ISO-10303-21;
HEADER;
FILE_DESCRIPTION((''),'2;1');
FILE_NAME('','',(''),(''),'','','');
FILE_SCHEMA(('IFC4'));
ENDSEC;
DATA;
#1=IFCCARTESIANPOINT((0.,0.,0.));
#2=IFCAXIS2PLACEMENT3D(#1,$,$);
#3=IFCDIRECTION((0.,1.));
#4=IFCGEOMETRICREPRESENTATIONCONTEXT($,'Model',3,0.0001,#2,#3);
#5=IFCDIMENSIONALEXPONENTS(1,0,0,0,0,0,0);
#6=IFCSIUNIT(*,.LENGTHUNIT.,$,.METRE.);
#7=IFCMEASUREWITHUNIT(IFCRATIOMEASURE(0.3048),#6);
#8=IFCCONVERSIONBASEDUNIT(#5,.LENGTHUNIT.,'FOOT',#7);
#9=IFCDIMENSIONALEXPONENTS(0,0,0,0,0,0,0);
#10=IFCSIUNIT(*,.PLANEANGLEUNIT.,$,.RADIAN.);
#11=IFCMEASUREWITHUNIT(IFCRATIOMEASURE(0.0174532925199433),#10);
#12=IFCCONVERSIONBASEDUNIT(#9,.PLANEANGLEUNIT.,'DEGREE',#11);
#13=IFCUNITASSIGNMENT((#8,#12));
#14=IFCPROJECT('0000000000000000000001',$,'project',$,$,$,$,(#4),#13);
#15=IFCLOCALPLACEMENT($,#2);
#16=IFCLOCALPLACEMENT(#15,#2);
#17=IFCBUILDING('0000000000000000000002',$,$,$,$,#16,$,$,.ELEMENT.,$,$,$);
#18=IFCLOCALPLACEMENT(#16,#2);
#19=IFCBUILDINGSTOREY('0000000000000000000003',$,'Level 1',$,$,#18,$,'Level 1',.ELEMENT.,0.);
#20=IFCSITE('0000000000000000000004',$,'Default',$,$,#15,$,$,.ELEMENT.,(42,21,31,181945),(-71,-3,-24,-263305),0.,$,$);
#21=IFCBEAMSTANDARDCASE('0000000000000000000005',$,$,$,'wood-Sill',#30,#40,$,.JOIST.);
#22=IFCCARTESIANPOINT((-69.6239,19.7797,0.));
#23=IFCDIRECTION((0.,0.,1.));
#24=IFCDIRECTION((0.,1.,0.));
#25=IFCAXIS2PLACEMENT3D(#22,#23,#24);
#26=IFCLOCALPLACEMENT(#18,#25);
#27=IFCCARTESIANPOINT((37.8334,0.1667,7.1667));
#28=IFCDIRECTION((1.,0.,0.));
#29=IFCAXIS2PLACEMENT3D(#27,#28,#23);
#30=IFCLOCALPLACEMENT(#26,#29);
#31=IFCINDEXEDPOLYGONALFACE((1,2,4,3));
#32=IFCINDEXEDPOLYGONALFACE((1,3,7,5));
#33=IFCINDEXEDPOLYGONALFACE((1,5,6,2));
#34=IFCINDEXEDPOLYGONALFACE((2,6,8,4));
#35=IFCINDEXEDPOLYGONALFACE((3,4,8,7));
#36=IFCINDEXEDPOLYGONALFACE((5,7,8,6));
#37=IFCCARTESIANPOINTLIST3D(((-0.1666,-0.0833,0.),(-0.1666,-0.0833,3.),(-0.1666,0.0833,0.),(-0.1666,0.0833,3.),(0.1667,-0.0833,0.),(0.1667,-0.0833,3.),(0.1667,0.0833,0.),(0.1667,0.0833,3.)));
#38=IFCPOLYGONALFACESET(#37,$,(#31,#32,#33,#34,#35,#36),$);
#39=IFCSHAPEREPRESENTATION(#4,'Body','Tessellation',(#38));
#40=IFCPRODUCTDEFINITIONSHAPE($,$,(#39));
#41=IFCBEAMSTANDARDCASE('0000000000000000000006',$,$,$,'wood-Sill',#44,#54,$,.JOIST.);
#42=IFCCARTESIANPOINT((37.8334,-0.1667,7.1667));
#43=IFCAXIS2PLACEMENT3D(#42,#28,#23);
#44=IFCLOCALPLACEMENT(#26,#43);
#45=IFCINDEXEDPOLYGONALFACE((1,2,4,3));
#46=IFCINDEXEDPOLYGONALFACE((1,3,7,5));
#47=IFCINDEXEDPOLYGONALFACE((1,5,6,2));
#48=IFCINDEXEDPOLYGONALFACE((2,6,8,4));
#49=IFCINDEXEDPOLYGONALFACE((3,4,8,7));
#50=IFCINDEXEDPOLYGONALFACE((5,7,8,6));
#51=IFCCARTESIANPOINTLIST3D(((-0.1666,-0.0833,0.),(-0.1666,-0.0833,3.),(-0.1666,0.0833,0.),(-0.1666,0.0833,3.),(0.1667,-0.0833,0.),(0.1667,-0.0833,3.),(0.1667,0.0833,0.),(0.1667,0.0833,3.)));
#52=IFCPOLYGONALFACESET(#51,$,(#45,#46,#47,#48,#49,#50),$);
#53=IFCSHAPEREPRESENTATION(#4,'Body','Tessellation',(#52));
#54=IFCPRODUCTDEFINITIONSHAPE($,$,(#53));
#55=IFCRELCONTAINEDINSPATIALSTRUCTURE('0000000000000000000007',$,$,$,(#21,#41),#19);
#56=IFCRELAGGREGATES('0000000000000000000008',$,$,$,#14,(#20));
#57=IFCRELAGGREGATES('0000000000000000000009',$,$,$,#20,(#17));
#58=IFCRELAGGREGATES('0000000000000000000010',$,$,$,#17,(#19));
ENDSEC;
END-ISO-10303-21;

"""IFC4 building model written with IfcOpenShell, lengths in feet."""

from ifc_helpers import new_model, entity, si_unit, converted_unit, direction, frame, origin, origin_with_axes, place, context, project, spatial, rectangle, extrude, element, save


model = new_model("IFC4")

# Units and contexts
model_context = context("Model", 3, precision=0.0001, world=origin(), true_north=direction((0.0, 1.0)))
ifc_project = project(units=[converted_unit("LENGTHUNIT", "FOOT", entity("IfcRatioMeasure", 0.3048), si_unit("LENGTHUNIT", "METRE"), dimensions=[1, 0, 0, 0, 0, 0, 0]), converted_unit("PLANEANGLEUNIT", "DEGREE", entity("IfcRatioMeasure", 0.0174532925199433), si_unit("PLANEANGLEUNIT", "RADIAN"), dimensions=[0, 0, 0, 0, 0, 0, 0])], contexts=[model_context])

# Site, building, storey
site_placement = place(None, origin())
site = spatial("IfcSite", under=ifc_project, at=site_placement, Name="Default", CompositionType="ELEMENT", RefLatitude=(42, 21, 31, 181945), RefLongitude=(-71, -3, -24, -263305), RefElevation=0.0)
building_placement = place(site_placement, origin())
building = spatial("IfcBuilding", under=site, at=building_placement, CompositionType="ELEMENT")
storey_placement = place(building_placement, origin())
storey = spatial("IfcBuildingStorey", under=building, at=storey_placement, Name="Level 1", LongName="Level 1", CompositionType="ELEMENT", Elevation=0.0)

# Shared definitions
placement_1 = place(storey_placement, frame((-69.6239, 19.7797, 0.0), z_axis=(0.0, 0.0, 1.0), x_axis=(0.0, 1.0, 0.0)))

# Beams
for number, where, z_axis, x_axis in (
    (1, (37.8334, 0.1667, 7.1667), (1.0, 0.0, 0.0), (0.0, 0.0, 1.0)),
    (2, (37.8334, -0.1667, 7.1667), (1.0, 0.0, 0.0), (0.0, 0.0, 1.0)),
):
    element("IfcBeamStandardCase", number, at=place(placement_1, frame(where, z_axis=z_axis, x_axis=x_axis)), inside=storey, ObjectType="wood-Sill", PredefinedType="JOIST", context=model_context, shape_type="SweptSolid", body=[
        extrude(rectangle(XDim=0.3333, YDim=0.1667), origin_with_axes(), (0.0, 0.0, 1.0), 3.0),
    ])

save(model, "model.ifc")
